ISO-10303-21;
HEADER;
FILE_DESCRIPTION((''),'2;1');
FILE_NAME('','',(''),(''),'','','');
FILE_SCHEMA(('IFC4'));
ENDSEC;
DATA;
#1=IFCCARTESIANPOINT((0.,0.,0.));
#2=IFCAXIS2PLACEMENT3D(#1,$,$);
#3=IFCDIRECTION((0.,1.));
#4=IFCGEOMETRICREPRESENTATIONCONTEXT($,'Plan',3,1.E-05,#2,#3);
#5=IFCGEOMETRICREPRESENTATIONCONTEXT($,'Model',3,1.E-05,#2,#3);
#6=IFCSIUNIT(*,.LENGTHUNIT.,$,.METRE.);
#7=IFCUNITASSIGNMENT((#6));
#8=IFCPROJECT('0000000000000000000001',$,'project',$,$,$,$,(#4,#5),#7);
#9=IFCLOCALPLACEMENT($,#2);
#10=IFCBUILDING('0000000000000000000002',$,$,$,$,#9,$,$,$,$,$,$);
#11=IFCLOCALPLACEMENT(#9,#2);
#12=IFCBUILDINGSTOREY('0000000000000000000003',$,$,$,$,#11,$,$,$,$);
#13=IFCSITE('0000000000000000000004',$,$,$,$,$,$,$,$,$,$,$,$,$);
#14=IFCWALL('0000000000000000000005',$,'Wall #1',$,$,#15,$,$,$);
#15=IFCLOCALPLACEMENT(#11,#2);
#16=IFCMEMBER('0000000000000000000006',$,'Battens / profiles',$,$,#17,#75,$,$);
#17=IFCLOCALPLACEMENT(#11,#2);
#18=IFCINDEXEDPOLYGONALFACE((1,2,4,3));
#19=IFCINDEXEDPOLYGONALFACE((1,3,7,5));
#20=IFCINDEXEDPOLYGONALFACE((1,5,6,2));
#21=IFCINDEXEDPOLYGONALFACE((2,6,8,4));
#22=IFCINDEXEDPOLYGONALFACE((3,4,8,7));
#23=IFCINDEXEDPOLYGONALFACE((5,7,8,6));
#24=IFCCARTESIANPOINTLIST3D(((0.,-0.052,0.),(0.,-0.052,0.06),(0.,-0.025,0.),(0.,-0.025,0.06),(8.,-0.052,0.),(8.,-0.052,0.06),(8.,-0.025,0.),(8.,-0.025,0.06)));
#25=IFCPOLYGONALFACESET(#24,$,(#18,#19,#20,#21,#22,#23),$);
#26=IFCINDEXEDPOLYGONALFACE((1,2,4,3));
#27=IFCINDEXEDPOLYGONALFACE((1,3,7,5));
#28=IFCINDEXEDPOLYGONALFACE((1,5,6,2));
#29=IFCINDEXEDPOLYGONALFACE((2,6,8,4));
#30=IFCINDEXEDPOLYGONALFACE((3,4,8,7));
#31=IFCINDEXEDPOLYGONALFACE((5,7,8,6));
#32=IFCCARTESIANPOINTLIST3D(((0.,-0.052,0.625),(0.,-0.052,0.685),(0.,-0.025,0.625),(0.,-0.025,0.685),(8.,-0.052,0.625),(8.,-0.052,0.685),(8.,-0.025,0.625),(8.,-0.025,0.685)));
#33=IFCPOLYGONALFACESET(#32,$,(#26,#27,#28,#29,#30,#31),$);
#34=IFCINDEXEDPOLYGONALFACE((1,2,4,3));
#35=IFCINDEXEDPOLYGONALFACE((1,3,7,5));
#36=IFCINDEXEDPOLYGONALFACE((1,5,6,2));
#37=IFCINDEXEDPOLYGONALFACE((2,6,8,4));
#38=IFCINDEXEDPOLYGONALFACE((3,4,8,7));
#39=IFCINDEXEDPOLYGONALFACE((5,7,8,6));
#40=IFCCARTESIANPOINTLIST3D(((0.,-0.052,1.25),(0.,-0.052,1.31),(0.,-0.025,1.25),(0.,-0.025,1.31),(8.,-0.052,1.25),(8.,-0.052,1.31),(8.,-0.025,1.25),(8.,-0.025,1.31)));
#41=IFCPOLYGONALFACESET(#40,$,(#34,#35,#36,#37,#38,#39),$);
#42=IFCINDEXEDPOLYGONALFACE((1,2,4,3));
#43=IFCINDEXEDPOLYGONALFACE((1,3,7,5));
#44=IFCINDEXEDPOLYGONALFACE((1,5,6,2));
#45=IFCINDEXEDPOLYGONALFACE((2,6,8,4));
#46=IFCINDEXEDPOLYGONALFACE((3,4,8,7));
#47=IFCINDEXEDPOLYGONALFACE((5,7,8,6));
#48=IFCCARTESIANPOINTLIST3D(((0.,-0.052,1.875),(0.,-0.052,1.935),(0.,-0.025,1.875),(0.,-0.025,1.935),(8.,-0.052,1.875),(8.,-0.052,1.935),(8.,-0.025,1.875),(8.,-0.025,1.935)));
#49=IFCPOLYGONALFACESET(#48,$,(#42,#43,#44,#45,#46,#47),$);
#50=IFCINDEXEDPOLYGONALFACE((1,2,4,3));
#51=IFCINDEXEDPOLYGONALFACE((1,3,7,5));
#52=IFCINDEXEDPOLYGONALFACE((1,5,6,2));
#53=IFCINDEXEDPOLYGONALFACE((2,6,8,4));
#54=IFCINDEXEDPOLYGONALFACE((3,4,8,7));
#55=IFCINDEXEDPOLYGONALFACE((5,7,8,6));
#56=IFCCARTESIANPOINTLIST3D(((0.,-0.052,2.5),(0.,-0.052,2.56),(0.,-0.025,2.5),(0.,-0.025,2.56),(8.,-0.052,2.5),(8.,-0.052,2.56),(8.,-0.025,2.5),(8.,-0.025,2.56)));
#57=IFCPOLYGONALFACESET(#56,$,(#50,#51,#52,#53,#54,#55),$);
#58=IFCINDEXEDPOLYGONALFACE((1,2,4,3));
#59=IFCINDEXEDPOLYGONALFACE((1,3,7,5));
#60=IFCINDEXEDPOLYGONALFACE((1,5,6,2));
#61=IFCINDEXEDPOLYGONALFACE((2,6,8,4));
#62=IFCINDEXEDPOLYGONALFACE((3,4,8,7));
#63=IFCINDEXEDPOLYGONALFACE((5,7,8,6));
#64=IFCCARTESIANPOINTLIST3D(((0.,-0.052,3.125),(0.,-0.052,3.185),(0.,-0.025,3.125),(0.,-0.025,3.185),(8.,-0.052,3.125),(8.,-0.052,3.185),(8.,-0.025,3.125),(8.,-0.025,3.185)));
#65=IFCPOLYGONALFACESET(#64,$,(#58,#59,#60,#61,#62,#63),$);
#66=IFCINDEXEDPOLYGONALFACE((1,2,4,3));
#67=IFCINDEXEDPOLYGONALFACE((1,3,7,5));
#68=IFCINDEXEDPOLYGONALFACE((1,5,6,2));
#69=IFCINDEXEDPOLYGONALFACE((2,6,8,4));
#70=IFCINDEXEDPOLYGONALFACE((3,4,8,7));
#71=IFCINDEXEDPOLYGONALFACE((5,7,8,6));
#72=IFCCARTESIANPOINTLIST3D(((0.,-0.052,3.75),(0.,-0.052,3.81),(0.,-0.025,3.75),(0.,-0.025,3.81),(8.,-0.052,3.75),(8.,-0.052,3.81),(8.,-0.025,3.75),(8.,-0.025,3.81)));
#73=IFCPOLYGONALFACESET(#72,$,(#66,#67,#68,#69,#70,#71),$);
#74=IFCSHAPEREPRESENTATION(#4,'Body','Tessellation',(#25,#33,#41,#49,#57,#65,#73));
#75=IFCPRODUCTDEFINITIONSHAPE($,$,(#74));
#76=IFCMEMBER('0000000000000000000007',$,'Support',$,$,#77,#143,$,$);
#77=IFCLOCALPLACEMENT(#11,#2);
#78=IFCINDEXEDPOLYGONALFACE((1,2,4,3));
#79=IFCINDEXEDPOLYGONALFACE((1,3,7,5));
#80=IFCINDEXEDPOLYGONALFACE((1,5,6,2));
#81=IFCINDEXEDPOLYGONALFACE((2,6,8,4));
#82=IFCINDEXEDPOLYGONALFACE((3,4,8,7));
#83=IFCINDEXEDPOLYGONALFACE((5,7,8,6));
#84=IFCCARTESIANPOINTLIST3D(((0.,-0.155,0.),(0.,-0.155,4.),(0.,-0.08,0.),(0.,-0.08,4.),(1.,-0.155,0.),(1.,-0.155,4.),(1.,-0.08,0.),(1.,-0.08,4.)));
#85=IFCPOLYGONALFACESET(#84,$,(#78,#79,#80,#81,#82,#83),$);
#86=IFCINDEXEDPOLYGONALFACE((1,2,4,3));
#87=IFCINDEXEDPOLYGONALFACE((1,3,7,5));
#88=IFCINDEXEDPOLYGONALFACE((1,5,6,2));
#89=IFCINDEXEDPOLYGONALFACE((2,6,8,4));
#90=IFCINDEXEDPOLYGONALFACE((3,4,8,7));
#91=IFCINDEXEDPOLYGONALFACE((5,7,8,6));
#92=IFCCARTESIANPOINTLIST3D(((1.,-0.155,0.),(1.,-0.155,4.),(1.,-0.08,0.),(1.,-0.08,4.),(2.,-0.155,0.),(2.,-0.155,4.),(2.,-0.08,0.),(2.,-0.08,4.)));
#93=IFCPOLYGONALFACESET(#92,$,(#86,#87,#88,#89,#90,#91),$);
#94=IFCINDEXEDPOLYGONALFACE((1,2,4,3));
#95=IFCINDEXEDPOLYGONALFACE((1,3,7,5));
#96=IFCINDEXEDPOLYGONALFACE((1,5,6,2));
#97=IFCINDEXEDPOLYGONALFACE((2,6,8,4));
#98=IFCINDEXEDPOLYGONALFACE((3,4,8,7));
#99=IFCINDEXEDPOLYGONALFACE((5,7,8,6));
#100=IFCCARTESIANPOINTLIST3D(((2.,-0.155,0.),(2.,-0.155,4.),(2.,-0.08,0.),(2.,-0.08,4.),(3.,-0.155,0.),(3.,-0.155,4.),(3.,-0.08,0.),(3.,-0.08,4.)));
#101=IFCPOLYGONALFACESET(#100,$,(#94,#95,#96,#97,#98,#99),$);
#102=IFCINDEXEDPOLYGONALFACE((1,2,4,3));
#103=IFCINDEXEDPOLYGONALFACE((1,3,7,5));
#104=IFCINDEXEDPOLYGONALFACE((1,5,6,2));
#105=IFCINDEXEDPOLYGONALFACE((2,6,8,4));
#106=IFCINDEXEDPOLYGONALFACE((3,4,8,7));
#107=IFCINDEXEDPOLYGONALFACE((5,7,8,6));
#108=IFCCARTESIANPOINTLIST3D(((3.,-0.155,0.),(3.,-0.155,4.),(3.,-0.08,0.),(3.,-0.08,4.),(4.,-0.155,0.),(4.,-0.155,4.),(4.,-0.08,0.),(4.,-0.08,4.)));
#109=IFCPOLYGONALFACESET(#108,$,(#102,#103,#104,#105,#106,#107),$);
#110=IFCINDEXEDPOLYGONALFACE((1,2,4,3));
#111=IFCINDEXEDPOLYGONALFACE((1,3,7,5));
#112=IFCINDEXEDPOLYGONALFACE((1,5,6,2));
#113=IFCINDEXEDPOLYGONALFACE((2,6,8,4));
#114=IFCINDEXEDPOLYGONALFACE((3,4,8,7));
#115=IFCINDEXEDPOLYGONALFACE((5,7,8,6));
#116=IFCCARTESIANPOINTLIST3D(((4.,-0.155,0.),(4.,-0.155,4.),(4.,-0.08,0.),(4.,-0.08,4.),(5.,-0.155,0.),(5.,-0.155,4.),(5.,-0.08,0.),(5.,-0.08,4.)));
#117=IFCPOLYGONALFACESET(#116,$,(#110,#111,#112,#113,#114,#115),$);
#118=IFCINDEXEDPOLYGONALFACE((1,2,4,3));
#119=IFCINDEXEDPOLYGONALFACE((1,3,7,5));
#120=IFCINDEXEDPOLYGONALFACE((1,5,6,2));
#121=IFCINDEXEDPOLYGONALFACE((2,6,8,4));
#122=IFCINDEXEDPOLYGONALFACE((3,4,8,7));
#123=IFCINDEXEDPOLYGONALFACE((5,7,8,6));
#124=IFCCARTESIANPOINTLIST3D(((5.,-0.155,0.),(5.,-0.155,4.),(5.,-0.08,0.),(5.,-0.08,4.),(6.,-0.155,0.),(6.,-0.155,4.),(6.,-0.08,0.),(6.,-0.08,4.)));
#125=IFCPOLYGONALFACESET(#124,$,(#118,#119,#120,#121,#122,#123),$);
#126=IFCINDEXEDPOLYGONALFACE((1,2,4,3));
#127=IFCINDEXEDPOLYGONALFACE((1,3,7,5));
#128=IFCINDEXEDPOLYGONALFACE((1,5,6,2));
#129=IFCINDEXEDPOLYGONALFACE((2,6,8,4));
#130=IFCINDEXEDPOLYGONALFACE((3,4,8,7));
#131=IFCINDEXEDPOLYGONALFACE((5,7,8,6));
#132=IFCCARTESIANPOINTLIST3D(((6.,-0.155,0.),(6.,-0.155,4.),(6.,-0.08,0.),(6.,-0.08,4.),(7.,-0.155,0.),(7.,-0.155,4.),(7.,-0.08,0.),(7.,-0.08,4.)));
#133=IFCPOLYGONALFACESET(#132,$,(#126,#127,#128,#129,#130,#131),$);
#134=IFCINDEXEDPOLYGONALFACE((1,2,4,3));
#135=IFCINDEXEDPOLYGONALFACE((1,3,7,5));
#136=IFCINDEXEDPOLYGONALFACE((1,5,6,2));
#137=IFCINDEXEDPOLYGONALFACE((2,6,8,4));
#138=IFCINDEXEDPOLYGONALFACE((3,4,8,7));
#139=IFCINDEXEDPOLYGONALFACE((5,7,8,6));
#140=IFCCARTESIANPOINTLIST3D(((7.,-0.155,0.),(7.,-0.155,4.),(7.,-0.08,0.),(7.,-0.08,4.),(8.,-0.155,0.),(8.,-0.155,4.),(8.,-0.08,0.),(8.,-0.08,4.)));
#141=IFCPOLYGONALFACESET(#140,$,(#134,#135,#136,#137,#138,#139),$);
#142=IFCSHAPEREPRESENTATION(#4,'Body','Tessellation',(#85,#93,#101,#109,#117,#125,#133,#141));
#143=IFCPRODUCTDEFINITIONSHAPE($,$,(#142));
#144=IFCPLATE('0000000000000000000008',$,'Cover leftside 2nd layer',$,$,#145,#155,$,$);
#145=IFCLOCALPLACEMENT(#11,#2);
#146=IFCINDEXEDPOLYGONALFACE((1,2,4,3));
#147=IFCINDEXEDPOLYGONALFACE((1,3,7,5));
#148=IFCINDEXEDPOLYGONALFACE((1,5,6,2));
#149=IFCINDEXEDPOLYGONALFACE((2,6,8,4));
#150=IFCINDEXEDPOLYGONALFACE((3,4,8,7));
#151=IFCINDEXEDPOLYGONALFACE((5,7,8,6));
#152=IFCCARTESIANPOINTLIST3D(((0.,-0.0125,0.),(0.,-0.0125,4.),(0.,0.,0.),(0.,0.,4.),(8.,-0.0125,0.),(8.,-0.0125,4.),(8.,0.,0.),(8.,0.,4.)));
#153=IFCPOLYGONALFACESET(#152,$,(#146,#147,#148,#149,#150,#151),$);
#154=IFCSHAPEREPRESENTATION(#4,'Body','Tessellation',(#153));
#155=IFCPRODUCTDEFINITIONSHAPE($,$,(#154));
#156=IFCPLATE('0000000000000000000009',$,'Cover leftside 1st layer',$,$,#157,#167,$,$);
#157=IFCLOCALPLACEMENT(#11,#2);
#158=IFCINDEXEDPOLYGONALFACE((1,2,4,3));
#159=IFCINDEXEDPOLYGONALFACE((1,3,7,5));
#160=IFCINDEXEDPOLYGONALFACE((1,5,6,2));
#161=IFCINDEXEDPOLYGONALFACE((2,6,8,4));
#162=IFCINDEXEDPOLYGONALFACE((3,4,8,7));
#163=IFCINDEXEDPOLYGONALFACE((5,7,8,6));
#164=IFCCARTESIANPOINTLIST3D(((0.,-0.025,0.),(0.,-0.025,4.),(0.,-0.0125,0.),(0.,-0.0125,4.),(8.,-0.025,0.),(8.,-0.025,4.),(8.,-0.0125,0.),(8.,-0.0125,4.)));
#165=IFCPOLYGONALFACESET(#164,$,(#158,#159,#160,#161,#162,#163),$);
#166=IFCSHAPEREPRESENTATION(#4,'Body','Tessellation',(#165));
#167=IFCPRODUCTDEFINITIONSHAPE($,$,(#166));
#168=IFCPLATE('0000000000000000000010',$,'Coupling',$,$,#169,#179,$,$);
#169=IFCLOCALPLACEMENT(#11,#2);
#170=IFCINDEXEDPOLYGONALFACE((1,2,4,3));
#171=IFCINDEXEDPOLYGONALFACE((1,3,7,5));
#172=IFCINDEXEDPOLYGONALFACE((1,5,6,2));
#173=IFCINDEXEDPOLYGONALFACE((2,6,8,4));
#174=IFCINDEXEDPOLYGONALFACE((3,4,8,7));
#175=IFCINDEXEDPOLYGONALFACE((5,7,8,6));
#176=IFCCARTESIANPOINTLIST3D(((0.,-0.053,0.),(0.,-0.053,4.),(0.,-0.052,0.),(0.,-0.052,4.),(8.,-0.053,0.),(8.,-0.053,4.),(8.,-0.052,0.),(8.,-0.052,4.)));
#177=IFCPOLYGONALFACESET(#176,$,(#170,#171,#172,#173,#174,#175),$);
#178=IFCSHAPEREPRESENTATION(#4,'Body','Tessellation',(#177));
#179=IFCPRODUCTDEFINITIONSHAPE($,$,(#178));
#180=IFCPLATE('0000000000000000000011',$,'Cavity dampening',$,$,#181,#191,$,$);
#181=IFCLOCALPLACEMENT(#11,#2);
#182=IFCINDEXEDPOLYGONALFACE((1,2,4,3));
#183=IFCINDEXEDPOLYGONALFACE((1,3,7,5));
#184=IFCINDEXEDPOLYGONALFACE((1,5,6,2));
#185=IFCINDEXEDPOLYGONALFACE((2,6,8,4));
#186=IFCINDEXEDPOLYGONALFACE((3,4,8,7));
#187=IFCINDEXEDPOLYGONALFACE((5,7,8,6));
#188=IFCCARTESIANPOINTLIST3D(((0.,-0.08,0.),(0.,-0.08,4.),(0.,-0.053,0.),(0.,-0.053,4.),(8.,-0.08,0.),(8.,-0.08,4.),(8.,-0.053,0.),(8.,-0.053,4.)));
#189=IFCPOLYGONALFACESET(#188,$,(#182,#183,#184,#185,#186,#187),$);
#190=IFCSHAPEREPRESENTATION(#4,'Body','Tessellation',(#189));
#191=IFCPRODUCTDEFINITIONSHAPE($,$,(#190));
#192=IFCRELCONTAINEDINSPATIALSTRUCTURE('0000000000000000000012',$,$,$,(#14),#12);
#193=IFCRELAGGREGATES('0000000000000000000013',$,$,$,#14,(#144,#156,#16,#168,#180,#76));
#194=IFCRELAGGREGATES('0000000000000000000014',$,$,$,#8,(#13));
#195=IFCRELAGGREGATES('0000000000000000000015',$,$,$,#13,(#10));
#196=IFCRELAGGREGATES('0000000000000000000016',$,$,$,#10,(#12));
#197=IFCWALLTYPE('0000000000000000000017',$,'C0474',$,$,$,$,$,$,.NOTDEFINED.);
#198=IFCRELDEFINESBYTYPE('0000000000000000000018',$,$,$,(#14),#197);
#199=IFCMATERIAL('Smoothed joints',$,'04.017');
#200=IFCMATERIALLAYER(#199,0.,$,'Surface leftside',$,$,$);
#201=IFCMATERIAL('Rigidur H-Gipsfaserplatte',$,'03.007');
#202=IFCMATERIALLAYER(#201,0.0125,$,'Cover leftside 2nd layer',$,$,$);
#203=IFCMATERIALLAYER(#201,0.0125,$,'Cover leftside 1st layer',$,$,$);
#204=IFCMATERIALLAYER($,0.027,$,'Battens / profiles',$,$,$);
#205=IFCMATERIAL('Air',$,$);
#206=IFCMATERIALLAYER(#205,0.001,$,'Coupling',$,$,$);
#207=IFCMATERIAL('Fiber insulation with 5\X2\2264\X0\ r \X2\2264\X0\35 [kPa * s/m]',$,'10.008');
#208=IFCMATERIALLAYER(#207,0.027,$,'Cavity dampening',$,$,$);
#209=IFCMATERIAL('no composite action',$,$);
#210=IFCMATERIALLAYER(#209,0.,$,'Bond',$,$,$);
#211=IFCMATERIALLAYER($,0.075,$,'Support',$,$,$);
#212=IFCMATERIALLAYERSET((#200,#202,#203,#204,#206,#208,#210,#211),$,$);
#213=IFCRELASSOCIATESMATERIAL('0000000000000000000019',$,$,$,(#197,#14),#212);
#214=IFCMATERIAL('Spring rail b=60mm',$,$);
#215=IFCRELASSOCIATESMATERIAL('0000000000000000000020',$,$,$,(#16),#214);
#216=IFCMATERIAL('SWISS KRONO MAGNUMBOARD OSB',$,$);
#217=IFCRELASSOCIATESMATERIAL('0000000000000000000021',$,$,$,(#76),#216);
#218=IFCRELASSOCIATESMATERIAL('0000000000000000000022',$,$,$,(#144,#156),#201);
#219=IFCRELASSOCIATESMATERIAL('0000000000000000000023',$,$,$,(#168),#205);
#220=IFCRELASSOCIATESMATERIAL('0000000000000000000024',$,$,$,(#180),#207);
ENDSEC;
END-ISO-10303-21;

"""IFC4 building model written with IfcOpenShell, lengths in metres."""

from ifc_helpers import new_model, si_unit, direction, frame, frame_2d, origin, origin_with_axes, place, context, project, spatial, rectangle, extrude, material, layer, layer_set, type_object, element, aggregate, save


model = new_model("IFC4")

# Units and contexts
plan_context = context("Plan", 3, precision=1e-05, world=origin(), true_north=direction((0.0, 1.0)))
model_context = context("Model", 3, precision=1e-05, world=origin(), true_north=direction((0.0, 1.0)))
ifc_project = project(units=[si_unit("LENGTHUNIT", "METRE")], contexts=[plan_context, model_context])

# Site, building, storey
site = spatial("IfcSite", under=ifc_project)
building_placement = place(None, origin())
building = spatial("IfcBuilding", under=site, at=building_placement)
storey_placement = place(building_placement, origin())
storey = spatial("IfcBuildingStorey", under=building, at=storey_placement)

# Wall, members, plates
ifc_material_1 = material(Name="Smoothed joints", Category="04.017")
ifc_layer_1 = layer(ifc_material_1, 0.0, Name="Surface leftside")
ifc_material_2 = material(Name="Rigidur H-Gipsfaserplatte", Category="03.007")
ifc_layer_2 = layer(ifc_material_2, 0.0125, Name="Cover leftside 2nd layer")
ifc_layer_3 = layer(ifc_material_2, 0.0125, Name="Cover leftside 1st layer")
ifc_layer_4 = layer(None, 0.027, Name="Battens / profiles")
ifc_material_3 = material(Name="Air")
ifc_layer_5 = layer(ifc_material_3, 0.001, Name="Coupling")
ifc_material_4 = material(Name="Fiber insulation with 5≤ r ≤35 [kPa * s/m]", Category="10.008")
ifc_layer_6 = layer(ifc_material_4, 0.027, Name="Cavity dampening")
ifc_material_5 = material(Name="no composite action")
ifc_layer_7 = layer(ifc_material_5, 0.0, Name="Bond")
ifc_layer_8 = layer(None, 0.075, Name="Support")
ifc_layer_set = layer_set([ifc_layer_1, ifc_layer_2, ifc_layer_3, ifc_layer_4, ifc_layer_5, ifc_layer_6, ifc_layer_7, ifc_layer_8])
wall_type = type_object("IfcWallType", Name="C0474", PredefinedType="NOTDEFINED", material=ifc_layer_set)
wall_placement = place(None, frame((0.0, 0.0, 0.0), z_axis=(0.0, -1.0, 0.0), x_axis=(1.0, 0.0, 0.0)))
wall = element("IfcWall", 1, at=wall_placement, inside=storey, type_object=wall_type, material=ifc_layer_set, Name="Wall #1")
ifc_material_6 = material(Name="Spring rail b=60mm")
member_1_placement = place(wall_placement, origin())
member_1 = element("IfcMember", 2, at=member_1_placement, material=ifc_material_6, Name="Battens / profiles", context=plan_context, shape_type="SweptSolid", body=[
    extrude(rectangle(XDim=0.06, YDim=0.027, at=frame_2d((0.03, 0.0135), x_axis=(1.0, 0.0))), frame((0.0, 0.0, 0.025), z_axis=(1.0, 0.0, 0.0), x_axis=(0.0, 1.0, 0.0)), (0.0, 0.0, 1.0), 8.0),
    extrude(rectangle(XDim=0.06, YDim=0.027, at=frame_2d((0.03, 0.0135), x_axis=(1.0, 0.0))), frame((0.0, 0.625, 0.025), z_axis=(1.0, 0.0, 0.0), x_axis=(0.0, 1.0, 0.0)), (0.0, 0.0, 1.0), 8.0),
    extrude(rectangle(XDim=0.06, YDim=0.027, at=frame_2d((0.03, 0.0135), x_axis=(1.0, 0.0))), frame((0.0, 1.25, 0.025), z_axis=(1.0, 0.0, 0.0), x_axis=(0.0, 1.0, 0.0)), (0.0, 0.0, 1.0), 8.0),
    extrude(rectangle(XDim=0.06, YDim=0.027, at=frame_2d((0.03, 0.0135), x_axis=(1.0, 0.0))), frame((0.0, 1.875, 0.025), z_axis=(1.0, 0.0, 0.0), x_axis=(0.0, 1.0, 0.0)), (0.0, 0.0, 1.0), 8.0),
    extrude(rectangle(XDim=0.06, YDim=0.027, at=frame_2d((0.03, 0.0135), x_axis=(1.0, 0.0))), frame((0.0, 2.5, 0.025), z_axis=(1.0, 0.0, 0.0), x_axis=(0.0, 1.0, 0.0)), (0.0, 0.0, 1.0), 8.0),
    extrude(rectangle(XDim=0.06, YDim=0.027, at=frame_2d((0.03, 0.0135), x_axis=(1.0, 0.0))), frame((0.0, 3.125, 0.025), z_axis=(1.0, 0.0, 0.0), x_axis=(0.0, 1.0, 0.0)), (0.0, 0.0, 1.0), 8.0),
    extrude(rectangle(XDim=0.06, YDim=0.027, at=frame_2d((0.03, 0.0135), x_axis=(1.0, 0.0))), frame((0.0, 3.75, 0.025), z_axis=(1.0, 0.0, 0.0), x_axis=(0.0, 1.0, 0.0)), (0.0, 0.0, 1.0), 8.0),
])
ifc_material_7 = material(Name="SWISS KRONO MAGNUMBOARD OSB")
member_2_placement = place(wall_placement, origin())
member_2 = element("IfcMember", 3, at=member_2_placement, material=ifc_material_7, Name="Support", context=plan_context, shape_type="SweptSolid", body=[
    extrude(rectangle(XDim=1.0, YDim=0.075, at=frame_2d((0.5, 0.0375), x_axis=(1.0, 0.0))), frame((0.0, 4.0, 0.08), z_axis=(0.0, -1.0, 0.0), x_axis=(1.0, 0.0, 0.0)), (0.0, 0.0, 1.0), 4.0),
    extrude(rectangle(XDim=1.0, YDim=0.075, at=frame_2d((0.5, 0.0375), x_axis=(1.0, 0.0))), frame((1.0, 4.0, 0.08), z_axis=(0.0, -1.0, 0.0), x_axis=(1.0, 0.0, 0.0)), (0.0, 0.0, 1.0), 4.0),
    extrude(rectangle(XDim=1.0, YDim=0.075, at=frame_2d((0.5, 0.0375), x_axis=(1.0, 0.0))), frame((2.0, 4.0, 0.08), z_axis=(0.0, -1.0, 0.0), x_axis=(1.0, 0.0, 0.0)), (0.0, 0.0, 1.0), 4.0),
    extrude(rectangle(XDim=1.0, YDim=0.075, at=frame_2d((0.5, 0.0375), x_axis=(1.0, 0.0))), frame((3.0, 4.0, 0.08), z_axis=(0.0, -1.0, 0.0), x_axis=(1.0, 0.0, 0.0)), (0.0, 0.0, 1.0), 4.0),
    extrude(rectangle(XDim=1.0, YDim=0.075, at=frame_2d((0.5, 0.0375), x_axis=(1.0, 0.0))), frame((4.0, 4.0, 0.08), z_axis=(0.0, -1.0, 0.0), x_axis=(1.0, 0.0, 0.0)), (0.0, 0.0, 1.0), 4.0),
    extrude(rectangle(XDim=1.0, YDim=0.075, at=frame_2d((0.5, 0.0375), x_axis=(1.0, 0.0))), frame((5.0, 4.0, 0.08), z_axis=(0.0, -1.0, 0.0), x_axis=(1.0, 0.0, 0.0)), (0.0, 0.0, 1.0), 4.0),
    extrude(rectangle(XDim=1.0, YDim=0.075, at=frame_2d((0.5, 0.0375), x_axis=(1.0, 0.0))), frame((6.0, 4.0, 0.08), z_axis=(0.0, -1.0, 0.0), x_axis=(1.0, 0.0, 0.0)), (0.0, 0.0, 1.0), 4.0),
    extrude(rectangle(XDim=1.0, YDim=0.075, at=frame_2d((0.5, 0.0375), x_axis=(1.0, 0.0))), frame((7.0, 4.0, 0.08), z_axis=(0.0, -1.0, 0.0), x_axis=(1.0, 0.0, 0.0)), (0.0, 0.0, 1.0), 4.0),
])
plate_1_placement = place(wall_placement, origin())
plate_1 = element("IfcPlate", 4, at=plate_1_placement, material=ifc_material_2, Name="Cover leftside 2nd layer", context=plan_context, shape_type="SweptSolid", body=[
    extrude(rectangle(XDim=8.0, YDim=4.0, at=frame_2d((4.0, 2.0), x_axis=(1.0, 0.0))), origin_with_axes(), (0.0, 0.0, 1.0), 0.0125),
])
plate_2_placement = place(wall_placement, origin())
plate_2 = element("IfcPlate", 5, at=plate_2_placement, material=ifc_material_2, Name="Cover leftside 1st layer", context=plan_context, shape_type="SweptSolid", body=[
    extrude(rectangle(XDim=8.0, YDim=4.0, at=frame_2d((4.0, 2.0), x_axis=(1.0, 0.0))), frame((0.0, 0.0, 0.0125), z_axis=(0.0, 0.0, 1.0), x_axis=(1.0, 0.0, 0.0)), (0.0, 0.0, 1.0), 0.0125),
])
plate_3_placement = place(wall_placement, origin())
plate_3 = element("IfcPlate", 6, at=plate_3_placement, material=ifc_material_3, Name="Coupling", context=plan_context, shape_type="SweptSolid", body=[
    extrude(rectangle(XDim=8.0, YDim=4.0, at=frame_2d((4.0, 2.0), x_axis=(1.0, 0.0))), frame((0.0, 0.0, 0.052), z_axis=(0.0, 0.0, 1.0), x_axis=(1.0, 0.0, 0.0)), (0.0, 0.0, 1.0), 0.001),
])
plate_4_placement = place(wall_placement, origin())
plate_4 = element("IfcPlate", 7, at=plate_4_placement, material=ifc_material_4, Name="Cavity dampening", context=plan_context, shape_type="SweptSolid", body=[
    extrude(rectangle(XDim=8.0, YDim=4.0, at=frame_2d((4.0, 2.0), x_axis=(1.0, 0.0))), frame((0.0, 0.0, 0.053), z_axis=(0.0, 0.0, 1.0), x_axis=(1.0, 0.0, 0.0)), (0.0, 0.0, 1.0), 0.027),
])
aggregate(wall, [plate_1, plate_2, member_1, plate_3, plate_4, member_2])

save(model, "model.ifc")
